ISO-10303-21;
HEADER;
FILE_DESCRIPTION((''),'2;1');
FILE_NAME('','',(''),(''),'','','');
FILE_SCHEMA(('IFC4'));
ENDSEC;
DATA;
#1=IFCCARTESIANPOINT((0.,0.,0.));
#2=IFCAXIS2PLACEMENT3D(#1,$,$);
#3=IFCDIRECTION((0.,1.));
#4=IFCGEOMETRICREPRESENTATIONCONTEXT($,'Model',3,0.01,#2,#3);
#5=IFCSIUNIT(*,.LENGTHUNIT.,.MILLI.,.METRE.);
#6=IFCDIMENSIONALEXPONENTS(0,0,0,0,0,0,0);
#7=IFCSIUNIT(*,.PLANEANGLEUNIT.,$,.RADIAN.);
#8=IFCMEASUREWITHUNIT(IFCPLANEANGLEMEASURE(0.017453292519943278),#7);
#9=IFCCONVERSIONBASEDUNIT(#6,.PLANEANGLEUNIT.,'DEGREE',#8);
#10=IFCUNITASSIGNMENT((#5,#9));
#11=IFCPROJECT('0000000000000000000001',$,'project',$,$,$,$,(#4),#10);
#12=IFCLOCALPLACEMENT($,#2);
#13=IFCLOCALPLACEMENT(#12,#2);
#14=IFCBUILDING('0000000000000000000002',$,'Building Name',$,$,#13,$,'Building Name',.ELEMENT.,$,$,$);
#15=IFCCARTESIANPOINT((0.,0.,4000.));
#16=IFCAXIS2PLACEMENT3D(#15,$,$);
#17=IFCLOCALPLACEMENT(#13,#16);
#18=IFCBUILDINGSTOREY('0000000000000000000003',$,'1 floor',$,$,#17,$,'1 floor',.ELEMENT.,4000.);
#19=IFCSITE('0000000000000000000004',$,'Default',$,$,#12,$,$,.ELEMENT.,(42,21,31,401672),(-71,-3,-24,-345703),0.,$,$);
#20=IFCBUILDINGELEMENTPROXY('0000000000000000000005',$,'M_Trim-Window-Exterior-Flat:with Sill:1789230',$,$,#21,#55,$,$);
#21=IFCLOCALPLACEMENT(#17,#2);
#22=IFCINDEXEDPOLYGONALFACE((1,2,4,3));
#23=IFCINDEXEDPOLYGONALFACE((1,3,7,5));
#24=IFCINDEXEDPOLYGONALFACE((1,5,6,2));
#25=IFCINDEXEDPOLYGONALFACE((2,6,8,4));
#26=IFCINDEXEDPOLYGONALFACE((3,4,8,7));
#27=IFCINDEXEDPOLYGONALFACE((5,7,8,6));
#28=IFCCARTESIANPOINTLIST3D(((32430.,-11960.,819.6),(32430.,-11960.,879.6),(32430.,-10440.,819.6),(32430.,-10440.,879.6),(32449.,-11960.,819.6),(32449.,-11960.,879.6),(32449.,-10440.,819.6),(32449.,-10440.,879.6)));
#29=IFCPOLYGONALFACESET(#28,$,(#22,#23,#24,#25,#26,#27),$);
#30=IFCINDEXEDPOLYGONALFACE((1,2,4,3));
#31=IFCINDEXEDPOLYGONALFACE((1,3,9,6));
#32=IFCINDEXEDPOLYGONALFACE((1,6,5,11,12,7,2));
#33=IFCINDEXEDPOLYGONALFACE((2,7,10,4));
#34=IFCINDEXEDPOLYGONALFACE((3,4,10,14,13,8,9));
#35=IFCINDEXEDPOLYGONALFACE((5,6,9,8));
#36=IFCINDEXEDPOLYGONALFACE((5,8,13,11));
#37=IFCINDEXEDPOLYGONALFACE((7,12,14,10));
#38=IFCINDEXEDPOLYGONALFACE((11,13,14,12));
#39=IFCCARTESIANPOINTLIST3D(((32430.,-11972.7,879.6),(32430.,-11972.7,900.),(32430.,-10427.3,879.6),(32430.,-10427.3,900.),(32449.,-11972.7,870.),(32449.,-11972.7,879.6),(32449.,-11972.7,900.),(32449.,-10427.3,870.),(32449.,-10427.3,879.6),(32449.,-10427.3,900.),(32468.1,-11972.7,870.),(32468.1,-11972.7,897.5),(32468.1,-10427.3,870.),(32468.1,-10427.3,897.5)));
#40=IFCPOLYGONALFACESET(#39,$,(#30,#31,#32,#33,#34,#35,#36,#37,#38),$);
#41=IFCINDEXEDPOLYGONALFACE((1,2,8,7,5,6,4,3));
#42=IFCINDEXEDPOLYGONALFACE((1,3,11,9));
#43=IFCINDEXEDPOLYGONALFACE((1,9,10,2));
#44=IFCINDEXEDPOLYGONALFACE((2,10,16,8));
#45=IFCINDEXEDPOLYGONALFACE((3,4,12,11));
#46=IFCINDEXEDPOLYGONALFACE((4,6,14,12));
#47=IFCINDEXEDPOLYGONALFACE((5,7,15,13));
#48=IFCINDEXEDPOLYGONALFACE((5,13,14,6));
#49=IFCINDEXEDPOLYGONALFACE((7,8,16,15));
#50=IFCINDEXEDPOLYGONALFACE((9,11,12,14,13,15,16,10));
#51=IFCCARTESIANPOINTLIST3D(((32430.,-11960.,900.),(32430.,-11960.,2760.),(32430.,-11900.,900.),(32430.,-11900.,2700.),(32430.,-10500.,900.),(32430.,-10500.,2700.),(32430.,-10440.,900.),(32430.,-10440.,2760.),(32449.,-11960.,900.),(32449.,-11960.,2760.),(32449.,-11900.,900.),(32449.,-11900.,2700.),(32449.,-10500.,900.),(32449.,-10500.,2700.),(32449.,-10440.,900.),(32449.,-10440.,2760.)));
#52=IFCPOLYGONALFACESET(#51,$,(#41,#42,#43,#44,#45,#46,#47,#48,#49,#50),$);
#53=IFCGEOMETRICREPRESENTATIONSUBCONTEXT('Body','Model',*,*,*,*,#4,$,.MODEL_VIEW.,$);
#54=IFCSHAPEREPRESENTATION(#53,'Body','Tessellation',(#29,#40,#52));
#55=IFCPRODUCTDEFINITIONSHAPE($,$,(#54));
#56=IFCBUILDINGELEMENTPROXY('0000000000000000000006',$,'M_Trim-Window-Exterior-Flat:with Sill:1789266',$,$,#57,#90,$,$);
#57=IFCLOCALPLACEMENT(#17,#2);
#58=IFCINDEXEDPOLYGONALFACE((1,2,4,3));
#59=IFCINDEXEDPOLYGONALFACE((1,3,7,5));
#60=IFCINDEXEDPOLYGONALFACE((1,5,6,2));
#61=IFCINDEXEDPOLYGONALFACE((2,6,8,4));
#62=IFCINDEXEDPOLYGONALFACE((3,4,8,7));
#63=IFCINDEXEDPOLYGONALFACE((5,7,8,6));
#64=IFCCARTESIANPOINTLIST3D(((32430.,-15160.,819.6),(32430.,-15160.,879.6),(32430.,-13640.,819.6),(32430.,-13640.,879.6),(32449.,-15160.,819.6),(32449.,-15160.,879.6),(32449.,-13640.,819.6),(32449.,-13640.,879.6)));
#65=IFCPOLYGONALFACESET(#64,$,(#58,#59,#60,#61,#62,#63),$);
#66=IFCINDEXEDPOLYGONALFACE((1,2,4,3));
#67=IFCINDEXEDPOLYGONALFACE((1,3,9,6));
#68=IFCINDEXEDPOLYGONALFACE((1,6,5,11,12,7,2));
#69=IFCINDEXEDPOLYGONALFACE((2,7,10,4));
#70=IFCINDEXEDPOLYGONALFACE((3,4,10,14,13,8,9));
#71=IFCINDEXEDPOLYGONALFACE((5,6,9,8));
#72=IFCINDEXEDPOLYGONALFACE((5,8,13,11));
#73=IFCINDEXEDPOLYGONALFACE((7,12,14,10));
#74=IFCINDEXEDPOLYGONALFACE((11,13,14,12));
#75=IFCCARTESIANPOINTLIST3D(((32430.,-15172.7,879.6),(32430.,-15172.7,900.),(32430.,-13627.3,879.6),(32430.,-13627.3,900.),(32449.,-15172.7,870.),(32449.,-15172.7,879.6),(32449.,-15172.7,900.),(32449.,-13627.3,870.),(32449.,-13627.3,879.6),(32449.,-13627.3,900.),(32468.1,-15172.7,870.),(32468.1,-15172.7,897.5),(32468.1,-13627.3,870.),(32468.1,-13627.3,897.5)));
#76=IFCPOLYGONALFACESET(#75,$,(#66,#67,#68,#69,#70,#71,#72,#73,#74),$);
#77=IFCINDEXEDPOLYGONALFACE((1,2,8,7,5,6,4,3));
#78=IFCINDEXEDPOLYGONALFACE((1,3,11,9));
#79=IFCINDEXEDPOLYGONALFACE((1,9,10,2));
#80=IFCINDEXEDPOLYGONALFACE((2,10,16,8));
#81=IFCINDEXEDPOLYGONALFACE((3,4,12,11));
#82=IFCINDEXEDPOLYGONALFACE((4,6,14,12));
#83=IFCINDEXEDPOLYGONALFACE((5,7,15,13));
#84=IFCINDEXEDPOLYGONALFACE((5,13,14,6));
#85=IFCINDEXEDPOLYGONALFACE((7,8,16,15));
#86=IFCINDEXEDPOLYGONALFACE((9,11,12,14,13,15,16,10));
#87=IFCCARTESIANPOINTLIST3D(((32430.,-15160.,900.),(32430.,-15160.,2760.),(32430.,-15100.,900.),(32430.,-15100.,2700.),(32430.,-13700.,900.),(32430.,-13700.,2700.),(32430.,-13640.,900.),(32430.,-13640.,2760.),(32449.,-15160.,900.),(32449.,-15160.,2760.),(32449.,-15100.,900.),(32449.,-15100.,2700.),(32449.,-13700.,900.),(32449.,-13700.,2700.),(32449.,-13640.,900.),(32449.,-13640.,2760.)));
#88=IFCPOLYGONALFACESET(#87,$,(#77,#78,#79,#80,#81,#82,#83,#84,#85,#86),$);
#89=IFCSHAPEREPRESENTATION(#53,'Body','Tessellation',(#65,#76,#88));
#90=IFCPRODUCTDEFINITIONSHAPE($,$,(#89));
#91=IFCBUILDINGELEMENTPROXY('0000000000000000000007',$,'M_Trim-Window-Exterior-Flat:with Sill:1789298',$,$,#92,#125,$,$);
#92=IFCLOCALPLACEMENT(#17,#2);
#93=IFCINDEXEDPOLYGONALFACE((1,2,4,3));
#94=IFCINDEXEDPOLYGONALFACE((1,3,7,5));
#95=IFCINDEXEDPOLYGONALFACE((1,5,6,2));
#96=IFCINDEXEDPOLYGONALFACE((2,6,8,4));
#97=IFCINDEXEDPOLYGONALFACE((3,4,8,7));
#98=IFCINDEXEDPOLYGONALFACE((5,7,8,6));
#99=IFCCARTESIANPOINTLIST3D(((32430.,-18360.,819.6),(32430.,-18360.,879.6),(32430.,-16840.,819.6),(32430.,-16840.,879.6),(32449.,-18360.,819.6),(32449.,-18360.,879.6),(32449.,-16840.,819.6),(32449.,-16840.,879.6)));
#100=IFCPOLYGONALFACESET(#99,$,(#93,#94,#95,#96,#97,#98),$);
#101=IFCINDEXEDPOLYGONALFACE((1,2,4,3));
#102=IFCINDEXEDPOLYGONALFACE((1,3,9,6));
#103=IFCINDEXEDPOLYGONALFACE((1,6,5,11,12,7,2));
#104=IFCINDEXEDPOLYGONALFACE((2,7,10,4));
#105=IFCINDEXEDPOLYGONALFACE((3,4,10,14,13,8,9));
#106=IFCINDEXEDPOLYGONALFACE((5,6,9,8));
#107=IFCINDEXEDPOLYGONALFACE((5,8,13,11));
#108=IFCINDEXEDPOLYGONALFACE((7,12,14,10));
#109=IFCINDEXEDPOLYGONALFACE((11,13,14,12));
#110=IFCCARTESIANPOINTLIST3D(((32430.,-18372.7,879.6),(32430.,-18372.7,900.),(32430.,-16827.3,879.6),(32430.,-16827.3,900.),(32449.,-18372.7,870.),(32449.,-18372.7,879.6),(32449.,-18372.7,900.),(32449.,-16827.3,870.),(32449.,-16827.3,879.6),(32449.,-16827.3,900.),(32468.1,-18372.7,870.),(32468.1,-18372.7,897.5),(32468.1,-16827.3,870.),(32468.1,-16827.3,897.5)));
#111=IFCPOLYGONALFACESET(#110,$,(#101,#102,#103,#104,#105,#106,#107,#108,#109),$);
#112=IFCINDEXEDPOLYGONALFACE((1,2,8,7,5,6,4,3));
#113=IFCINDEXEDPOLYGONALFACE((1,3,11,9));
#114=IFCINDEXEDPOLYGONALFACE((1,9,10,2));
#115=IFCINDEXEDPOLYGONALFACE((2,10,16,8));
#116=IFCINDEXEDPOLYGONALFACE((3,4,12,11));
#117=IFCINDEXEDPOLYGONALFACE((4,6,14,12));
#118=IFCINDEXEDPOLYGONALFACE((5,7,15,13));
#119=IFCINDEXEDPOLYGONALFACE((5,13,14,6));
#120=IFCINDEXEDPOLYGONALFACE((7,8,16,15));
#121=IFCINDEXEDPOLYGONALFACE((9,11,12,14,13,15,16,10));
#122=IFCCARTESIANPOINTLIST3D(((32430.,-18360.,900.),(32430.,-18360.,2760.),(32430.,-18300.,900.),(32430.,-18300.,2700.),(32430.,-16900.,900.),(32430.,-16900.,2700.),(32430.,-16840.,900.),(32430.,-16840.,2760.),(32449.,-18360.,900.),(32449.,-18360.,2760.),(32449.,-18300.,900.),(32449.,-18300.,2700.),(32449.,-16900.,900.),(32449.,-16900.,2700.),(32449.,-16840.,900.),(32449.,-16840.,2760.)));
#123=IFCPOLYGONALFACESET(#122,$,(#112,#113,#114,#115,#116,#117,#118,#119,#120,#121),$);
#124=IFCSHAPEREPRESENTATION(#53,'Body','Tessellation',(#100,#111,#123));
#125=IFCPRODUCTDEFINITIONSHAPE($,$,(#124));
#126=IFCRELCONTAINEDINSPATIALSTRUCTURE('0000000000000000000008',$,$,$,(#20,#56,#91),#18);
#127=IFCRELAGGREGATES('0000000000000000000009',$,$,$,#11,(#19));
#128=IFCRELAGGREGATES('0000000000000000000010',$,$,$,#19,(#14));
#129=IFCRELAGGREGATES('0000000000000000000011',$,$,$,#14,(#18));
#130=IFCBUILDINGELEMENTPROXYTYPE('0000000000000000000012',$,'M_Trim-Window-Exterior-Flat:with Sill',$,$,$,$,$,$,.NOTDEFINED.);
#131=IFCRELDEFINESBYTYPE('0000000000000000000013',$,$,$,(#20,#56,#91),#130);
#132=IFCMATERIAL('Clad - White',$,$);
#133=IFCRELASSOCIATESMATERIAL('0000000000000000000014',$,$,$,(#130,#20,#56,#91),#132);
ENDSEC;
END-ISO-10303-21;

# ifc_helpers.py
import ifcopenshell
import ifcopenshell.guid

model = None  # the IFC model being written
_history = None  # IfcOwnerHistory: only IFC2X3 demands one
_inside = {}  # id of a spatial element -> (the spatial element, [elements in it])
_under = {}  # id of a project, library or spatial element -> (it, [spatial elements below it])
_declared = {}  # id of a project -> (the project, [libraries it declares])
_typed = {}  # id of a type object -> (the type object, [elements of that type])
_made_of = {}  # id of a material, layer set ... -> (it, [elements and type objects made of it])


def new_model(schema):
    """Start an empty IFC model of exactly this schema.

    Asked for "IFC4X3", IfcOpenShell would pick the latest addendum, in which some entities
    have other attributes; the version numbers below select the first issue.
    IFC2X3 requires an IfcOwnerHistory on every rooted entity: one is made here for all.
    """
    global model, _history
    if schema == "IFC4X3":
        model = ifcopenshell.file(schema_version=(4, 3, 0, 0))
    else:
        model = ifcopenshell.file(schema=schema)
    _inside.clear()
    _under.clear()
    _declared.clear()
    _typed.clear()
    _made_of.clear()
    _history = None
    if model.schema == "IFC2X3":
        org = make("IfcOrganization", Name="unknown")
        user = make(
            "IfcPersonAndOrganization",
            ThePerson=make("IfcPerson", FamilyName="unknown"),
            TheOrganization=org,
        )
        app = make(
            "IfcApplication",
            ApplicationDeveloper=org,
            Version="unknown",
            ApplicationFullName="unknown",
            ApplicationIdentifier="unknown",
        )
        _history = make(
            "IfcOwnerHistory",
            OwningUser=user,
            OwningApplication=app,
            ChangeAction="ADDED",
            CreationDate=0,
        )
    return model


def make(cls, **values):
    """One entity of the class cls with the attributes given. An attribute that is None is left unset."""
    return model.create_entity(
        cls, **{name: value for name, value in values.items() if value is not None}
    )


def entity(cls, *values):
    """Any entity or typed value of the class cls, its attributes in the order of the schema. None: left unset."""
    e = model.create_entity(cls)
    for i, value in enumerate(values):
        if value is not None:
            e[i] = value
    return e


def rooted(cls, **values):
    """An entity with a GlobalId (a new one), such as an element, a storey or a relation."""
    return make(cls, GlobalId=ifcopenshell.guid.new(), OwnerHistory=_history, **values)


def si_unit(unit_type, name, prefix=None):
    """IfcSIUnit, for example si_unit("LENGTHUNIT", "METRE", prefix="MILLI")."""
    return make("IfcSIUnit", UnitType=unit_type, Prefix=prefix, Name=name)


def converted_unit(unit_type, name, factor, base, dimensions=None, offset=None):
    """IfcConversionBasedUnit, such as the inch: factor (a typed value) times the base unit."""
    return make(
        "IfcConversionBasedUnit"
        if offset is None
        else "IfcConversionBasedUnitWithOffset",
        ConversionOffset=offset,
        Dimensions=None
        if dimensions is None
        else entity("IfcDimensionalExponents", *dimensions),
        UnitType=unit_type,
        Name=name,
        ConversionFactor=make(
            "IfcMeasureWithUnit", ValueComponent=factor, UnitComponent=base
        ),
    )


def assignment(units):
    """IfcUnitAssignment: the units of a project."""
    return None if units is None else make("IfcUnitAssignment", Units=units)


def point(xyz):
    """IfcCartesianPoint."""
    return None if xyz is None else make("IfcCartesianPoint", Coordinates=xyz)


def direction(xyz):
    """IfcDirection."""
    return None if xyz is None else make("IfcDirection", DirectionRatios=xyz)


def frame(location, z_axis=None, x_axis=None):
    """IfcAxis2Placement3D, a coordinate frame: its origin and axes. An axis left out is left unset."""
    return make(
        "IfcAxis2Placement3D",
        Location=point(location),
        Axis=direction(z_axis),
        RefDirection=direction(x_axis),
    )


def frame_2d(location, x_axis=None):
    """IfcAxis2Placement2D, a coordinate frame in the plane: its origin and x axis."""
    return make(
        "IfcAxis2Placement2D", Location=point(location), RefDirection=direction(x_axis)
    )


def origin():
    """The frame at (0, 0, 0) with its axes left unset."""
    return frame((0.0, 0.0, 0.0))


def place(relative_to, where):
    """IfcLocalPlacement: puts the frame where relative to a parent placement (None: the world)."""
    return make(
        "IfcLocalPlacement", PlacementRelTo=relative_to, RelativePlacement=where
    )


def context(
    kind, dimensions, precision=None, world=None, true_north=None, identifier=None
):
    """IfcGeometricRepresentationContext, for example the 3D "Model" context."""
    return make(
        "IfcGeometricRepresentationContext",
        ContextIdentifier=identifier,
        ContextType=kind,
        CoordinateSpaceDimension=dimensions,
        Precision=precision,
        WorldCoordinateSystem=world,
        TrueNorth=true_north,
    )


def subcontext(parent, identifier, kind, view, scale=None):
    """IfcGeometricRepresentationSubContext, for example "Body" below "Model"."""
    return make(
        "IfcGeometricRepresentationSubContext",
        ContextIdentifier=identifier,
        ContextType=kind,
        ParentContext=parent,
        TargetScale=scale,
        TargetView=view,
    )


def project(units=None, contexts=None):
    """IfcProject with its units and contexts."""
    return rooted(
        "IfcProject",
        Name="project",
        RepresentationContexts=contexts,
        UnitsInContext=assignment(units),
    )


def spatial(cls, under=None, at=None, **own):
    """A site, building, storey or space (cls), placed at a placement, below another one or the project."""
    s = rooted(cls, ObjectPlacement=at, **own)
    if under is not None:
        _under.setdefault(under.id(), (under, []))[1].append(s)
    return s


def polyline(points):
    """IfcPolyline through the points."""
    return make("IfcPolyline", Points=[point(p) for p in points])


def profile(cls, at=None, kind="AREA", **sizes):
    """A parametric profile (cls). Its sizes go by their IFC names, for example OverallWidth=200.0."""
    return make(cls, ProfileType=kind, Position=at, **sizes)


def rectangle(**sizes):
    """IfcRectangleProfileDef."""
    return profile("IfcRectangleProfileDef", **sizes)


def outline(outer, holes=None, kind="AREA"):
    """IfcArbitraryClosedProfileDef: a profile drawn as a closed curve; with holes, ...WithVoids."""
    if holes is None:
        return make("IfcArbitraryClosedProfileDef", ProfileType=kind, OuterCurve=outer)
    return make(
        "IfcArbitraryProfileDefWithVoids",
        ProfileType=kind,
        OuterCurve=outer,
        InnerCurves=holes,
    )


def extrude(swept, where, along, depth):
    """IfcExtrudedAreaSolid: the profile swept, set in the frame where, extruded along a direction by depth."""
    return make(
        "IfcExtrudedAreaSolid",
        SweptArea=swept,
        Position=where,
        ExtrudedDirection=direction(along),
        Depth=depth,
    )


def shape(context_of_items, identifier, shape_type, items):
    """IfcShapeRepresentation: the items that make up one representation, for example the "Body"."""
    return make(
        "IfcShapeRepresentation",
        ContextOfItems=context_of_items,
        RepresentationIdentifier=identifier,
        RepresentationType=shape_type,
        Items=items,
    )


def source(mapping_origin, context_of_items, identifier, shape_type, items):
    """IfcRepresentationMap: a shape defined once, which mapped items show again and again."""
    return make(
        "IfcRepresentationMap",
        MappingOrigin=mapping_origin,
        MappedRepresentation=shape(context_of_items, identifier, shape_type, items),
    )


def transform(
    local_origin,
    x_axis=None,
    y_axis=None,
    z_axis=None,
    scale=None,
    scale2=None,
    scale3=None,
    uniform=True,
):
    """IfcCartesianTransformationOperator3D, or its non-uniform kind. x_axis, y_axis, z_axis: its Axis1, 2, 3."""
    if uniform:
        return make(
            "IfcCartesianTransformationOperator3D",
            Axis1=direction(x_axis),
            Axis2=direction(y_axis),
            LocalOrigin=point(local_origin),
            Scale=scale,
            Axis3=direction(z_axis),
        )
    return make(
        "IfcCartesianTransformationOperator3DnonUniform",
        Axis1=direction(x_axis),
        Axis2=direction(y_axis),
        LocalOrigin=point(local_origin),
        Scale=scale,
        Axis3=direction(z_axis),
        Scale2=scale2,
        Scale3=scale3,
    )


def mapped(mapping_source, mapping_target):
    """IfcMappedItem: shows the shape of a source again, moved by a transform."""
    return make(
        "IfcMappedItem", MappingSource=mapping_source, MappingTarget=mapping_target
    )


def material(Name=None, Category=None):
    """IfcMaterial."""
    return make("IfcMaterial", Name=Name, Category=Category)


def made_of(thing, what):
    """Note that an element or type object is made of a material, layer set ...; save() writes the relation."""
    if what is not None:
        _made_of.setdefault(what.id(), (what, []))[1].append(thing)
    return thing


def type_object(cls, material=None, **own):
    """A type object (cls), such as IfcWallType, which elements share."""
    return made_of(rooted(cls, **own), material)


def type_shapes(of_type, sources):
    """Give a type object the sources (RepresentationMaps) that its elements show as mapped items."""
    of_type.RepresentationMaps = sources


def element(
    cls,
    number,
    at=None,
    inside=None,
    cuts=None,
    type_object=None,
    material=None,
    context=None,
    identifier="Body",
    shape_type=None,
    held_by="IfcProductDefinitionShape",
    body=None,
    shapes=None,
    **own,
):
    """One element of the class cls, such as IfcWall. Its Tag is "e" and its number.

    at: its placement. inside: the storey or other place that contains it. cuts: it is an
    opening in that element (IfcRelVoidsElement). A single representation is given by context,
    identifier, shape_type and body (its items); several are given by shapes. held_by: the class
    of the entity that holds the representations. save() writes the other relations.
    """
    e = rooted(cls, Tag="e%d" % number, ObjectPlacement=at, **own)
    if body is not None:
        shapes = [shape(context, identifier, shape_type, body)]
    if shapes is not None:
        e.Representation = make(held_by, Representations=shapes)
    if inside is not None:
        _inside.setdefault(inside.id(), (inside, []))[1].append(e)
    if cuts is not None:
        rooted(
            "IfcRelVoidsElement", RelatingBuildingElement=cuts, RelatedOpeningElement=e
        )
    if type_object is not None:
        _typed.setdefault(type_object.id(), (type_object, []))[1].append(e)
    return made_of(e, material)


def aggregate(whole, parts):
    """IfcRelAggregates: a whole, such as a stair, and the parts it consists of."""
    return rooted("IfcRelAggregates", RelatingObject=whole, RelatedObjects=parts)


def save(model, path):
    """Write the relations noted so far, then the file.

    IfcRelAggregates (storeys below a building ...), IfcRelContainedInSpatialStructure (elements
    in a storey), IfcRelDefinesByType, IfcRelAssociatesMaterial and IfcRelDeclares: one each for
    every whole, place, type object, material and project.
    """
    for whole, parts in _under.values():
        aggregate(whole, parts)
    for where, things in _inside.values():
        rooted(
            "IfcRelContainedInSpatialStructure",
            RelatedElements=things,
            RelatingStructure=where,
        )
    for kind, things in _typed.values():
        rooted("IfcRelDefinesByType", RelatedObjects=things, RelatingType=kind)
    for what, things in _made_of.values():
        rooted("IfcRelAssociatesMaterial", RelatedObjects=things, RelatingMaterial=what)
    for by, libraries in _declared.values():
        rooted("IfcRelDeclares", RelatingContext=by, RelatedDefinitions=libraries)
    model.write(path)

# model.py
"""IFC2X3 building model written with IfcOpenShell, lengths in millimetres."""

from ifc_helpers import new_model, entity, si_unit, converted_unit, direction, frame, frame_2d, origin, place, context, subcontext, project, spatial, polyline, rectangle, outline, extrude, source, transform, mapped, material, type_object, type_shapes, element, save


model = new_model("IFC2X3")

# Units and contexts
model_context = context("Model", 3, precision=0.01, world=origin(), true_north=direction((0.0, 1.0)))
body_context = subcontext(model_context, "Body", "Model", "MODEL_VIEW")
ifc_project = project(units=[si_unit("LENGTHUNIT", "METRE", prefix="MILLI"), converted_unit("PLANEANGLEUNIT", "DEGREE", entity("IfcPlaneAngleMeasure", 0.017453292519943278), si_unit("PLANEANGLEUNIT", "RADIAN"), dimensions=[0, 0, 0, 0, 0, 0, 0])], contexts=[model_context])

# Site, building, storey
site_placement = place(None, origin())
site = spatial("IfcSite", under=ifc_project, at=site_placement, Name="Default", CompositionType="ELEMENT", RefLatitude=(42, 21, 31, 401672), RefLongitude=(-71, -3, -24, -345703), RefElevation=0.0)
building_placement = place(site_placement, origin())
building = spatial("IfcBuilding", under=site, at=building_placement, Name="Building Name", LongName="Building Name", CompositionType="ELEMENT")
storey_placement = place(building_placement, frame((0.0, 0.0, 4000.0)))
storey = spatial("IfcBuildingStorey", under=building, at=storey_placement, Name="1 floor", LongName="1 floor", CompositionType="ELEMENT", Elevation=4000.0)

# Building element proxies
ifc_material_1 = material(Name="Clad - White")
building_element_proxy_type_1 = type_object("IfcBuildingElementProxyType", Name="M_Trim-Window-Exterior-Flat:with Sill", PredefinedType="NOTDEFINED", material=ifc_material_1)
shared_shape_1 = source(origin(), body_context, "Body", "SweptSolid", [
    extrude(rectangle(XDim=1520.0, YDim=60.0, at=frame_2d((0.0, 0.0), x_axis=(1.0, 0.0))), frame((0.0, -1850.4, 0.0), z_axis=(0.0, 0.0, 1.0), x_axis=(-1.0, 0.0, 0.0)), (0.0, 0.0, 1.0), 19.0),
    extrude(outline(polyline([(-19.0, -15.2), (0.0, -15.2), (0.0, -5.7), (19.0, -5.7), (19.0, 14.8), (0.0, 14.8), (-19.0, 12.3), (-19.0, -15.2)])), frame((-772.7, -1814.8, 19.0), z_axis=(1.0, 0.0, 0.0), x_axis=(0.0, 0.0, -1.0)), (0.0, 0.0, 1.0), 1545.4),
    extrude(outline(polyline([(-945.0, -760.0), (915.0, -760.0), (915.0, -700.0), (-885.0, -700.0), (-885.0, 700.0), (915.0, 700.0), (915.0, 760.0), (-945.0, 760.0), (-945.0, -760.0)])), frame((0.0, -885.0, 0.0), z_axis=(0.0, 0.0, 1.0), x_axis=(0.0, -1.0, 0.0)), (0.0, 0.0, 1.0), 19.0),
])
type_shapes(building_element_proxy_type_1, [shared_shape_1])
for number, where, z_axis, x_axis, name in (
    (1, (32430.0, -11200.0, 2700.0), (1.0, 0.0, 0.0), (0.0, 1.0, 0.0), "M_Trim-Window-Exterior-Flat:with Sill:1789230"),
    (2, (32430.0, -14400.0, 2700.0), (1.0, 0.0, 0.0), (0.0, 1.0, 0.0), "M_Trim-Window-Exterior-Flat:with Sill:1789266"),
    (3, (32430.0, -17600.0, 2700.0), (1.0, 0.0, 0.0), (0.0, 1.0, 0.0), "M_Trim-Window-Exterior-Flat:with Sill:1789298"),
):
    element("IfcBuildingElementProxy", number, at=place(storey_placement, frame(where, z_axis=z_axis, x_axis=x_axis)), inside=storey, type_object=building_element_proxy_type_1, material=ifc_material_1, Name=name, context=body_context, shape_type="MappedRepresentation", body=[
        mapped(shared_shape_1, transform((0.0, 0.0, 0.0), scale=1.0)),
    ])

save(model, "model.ifc")
